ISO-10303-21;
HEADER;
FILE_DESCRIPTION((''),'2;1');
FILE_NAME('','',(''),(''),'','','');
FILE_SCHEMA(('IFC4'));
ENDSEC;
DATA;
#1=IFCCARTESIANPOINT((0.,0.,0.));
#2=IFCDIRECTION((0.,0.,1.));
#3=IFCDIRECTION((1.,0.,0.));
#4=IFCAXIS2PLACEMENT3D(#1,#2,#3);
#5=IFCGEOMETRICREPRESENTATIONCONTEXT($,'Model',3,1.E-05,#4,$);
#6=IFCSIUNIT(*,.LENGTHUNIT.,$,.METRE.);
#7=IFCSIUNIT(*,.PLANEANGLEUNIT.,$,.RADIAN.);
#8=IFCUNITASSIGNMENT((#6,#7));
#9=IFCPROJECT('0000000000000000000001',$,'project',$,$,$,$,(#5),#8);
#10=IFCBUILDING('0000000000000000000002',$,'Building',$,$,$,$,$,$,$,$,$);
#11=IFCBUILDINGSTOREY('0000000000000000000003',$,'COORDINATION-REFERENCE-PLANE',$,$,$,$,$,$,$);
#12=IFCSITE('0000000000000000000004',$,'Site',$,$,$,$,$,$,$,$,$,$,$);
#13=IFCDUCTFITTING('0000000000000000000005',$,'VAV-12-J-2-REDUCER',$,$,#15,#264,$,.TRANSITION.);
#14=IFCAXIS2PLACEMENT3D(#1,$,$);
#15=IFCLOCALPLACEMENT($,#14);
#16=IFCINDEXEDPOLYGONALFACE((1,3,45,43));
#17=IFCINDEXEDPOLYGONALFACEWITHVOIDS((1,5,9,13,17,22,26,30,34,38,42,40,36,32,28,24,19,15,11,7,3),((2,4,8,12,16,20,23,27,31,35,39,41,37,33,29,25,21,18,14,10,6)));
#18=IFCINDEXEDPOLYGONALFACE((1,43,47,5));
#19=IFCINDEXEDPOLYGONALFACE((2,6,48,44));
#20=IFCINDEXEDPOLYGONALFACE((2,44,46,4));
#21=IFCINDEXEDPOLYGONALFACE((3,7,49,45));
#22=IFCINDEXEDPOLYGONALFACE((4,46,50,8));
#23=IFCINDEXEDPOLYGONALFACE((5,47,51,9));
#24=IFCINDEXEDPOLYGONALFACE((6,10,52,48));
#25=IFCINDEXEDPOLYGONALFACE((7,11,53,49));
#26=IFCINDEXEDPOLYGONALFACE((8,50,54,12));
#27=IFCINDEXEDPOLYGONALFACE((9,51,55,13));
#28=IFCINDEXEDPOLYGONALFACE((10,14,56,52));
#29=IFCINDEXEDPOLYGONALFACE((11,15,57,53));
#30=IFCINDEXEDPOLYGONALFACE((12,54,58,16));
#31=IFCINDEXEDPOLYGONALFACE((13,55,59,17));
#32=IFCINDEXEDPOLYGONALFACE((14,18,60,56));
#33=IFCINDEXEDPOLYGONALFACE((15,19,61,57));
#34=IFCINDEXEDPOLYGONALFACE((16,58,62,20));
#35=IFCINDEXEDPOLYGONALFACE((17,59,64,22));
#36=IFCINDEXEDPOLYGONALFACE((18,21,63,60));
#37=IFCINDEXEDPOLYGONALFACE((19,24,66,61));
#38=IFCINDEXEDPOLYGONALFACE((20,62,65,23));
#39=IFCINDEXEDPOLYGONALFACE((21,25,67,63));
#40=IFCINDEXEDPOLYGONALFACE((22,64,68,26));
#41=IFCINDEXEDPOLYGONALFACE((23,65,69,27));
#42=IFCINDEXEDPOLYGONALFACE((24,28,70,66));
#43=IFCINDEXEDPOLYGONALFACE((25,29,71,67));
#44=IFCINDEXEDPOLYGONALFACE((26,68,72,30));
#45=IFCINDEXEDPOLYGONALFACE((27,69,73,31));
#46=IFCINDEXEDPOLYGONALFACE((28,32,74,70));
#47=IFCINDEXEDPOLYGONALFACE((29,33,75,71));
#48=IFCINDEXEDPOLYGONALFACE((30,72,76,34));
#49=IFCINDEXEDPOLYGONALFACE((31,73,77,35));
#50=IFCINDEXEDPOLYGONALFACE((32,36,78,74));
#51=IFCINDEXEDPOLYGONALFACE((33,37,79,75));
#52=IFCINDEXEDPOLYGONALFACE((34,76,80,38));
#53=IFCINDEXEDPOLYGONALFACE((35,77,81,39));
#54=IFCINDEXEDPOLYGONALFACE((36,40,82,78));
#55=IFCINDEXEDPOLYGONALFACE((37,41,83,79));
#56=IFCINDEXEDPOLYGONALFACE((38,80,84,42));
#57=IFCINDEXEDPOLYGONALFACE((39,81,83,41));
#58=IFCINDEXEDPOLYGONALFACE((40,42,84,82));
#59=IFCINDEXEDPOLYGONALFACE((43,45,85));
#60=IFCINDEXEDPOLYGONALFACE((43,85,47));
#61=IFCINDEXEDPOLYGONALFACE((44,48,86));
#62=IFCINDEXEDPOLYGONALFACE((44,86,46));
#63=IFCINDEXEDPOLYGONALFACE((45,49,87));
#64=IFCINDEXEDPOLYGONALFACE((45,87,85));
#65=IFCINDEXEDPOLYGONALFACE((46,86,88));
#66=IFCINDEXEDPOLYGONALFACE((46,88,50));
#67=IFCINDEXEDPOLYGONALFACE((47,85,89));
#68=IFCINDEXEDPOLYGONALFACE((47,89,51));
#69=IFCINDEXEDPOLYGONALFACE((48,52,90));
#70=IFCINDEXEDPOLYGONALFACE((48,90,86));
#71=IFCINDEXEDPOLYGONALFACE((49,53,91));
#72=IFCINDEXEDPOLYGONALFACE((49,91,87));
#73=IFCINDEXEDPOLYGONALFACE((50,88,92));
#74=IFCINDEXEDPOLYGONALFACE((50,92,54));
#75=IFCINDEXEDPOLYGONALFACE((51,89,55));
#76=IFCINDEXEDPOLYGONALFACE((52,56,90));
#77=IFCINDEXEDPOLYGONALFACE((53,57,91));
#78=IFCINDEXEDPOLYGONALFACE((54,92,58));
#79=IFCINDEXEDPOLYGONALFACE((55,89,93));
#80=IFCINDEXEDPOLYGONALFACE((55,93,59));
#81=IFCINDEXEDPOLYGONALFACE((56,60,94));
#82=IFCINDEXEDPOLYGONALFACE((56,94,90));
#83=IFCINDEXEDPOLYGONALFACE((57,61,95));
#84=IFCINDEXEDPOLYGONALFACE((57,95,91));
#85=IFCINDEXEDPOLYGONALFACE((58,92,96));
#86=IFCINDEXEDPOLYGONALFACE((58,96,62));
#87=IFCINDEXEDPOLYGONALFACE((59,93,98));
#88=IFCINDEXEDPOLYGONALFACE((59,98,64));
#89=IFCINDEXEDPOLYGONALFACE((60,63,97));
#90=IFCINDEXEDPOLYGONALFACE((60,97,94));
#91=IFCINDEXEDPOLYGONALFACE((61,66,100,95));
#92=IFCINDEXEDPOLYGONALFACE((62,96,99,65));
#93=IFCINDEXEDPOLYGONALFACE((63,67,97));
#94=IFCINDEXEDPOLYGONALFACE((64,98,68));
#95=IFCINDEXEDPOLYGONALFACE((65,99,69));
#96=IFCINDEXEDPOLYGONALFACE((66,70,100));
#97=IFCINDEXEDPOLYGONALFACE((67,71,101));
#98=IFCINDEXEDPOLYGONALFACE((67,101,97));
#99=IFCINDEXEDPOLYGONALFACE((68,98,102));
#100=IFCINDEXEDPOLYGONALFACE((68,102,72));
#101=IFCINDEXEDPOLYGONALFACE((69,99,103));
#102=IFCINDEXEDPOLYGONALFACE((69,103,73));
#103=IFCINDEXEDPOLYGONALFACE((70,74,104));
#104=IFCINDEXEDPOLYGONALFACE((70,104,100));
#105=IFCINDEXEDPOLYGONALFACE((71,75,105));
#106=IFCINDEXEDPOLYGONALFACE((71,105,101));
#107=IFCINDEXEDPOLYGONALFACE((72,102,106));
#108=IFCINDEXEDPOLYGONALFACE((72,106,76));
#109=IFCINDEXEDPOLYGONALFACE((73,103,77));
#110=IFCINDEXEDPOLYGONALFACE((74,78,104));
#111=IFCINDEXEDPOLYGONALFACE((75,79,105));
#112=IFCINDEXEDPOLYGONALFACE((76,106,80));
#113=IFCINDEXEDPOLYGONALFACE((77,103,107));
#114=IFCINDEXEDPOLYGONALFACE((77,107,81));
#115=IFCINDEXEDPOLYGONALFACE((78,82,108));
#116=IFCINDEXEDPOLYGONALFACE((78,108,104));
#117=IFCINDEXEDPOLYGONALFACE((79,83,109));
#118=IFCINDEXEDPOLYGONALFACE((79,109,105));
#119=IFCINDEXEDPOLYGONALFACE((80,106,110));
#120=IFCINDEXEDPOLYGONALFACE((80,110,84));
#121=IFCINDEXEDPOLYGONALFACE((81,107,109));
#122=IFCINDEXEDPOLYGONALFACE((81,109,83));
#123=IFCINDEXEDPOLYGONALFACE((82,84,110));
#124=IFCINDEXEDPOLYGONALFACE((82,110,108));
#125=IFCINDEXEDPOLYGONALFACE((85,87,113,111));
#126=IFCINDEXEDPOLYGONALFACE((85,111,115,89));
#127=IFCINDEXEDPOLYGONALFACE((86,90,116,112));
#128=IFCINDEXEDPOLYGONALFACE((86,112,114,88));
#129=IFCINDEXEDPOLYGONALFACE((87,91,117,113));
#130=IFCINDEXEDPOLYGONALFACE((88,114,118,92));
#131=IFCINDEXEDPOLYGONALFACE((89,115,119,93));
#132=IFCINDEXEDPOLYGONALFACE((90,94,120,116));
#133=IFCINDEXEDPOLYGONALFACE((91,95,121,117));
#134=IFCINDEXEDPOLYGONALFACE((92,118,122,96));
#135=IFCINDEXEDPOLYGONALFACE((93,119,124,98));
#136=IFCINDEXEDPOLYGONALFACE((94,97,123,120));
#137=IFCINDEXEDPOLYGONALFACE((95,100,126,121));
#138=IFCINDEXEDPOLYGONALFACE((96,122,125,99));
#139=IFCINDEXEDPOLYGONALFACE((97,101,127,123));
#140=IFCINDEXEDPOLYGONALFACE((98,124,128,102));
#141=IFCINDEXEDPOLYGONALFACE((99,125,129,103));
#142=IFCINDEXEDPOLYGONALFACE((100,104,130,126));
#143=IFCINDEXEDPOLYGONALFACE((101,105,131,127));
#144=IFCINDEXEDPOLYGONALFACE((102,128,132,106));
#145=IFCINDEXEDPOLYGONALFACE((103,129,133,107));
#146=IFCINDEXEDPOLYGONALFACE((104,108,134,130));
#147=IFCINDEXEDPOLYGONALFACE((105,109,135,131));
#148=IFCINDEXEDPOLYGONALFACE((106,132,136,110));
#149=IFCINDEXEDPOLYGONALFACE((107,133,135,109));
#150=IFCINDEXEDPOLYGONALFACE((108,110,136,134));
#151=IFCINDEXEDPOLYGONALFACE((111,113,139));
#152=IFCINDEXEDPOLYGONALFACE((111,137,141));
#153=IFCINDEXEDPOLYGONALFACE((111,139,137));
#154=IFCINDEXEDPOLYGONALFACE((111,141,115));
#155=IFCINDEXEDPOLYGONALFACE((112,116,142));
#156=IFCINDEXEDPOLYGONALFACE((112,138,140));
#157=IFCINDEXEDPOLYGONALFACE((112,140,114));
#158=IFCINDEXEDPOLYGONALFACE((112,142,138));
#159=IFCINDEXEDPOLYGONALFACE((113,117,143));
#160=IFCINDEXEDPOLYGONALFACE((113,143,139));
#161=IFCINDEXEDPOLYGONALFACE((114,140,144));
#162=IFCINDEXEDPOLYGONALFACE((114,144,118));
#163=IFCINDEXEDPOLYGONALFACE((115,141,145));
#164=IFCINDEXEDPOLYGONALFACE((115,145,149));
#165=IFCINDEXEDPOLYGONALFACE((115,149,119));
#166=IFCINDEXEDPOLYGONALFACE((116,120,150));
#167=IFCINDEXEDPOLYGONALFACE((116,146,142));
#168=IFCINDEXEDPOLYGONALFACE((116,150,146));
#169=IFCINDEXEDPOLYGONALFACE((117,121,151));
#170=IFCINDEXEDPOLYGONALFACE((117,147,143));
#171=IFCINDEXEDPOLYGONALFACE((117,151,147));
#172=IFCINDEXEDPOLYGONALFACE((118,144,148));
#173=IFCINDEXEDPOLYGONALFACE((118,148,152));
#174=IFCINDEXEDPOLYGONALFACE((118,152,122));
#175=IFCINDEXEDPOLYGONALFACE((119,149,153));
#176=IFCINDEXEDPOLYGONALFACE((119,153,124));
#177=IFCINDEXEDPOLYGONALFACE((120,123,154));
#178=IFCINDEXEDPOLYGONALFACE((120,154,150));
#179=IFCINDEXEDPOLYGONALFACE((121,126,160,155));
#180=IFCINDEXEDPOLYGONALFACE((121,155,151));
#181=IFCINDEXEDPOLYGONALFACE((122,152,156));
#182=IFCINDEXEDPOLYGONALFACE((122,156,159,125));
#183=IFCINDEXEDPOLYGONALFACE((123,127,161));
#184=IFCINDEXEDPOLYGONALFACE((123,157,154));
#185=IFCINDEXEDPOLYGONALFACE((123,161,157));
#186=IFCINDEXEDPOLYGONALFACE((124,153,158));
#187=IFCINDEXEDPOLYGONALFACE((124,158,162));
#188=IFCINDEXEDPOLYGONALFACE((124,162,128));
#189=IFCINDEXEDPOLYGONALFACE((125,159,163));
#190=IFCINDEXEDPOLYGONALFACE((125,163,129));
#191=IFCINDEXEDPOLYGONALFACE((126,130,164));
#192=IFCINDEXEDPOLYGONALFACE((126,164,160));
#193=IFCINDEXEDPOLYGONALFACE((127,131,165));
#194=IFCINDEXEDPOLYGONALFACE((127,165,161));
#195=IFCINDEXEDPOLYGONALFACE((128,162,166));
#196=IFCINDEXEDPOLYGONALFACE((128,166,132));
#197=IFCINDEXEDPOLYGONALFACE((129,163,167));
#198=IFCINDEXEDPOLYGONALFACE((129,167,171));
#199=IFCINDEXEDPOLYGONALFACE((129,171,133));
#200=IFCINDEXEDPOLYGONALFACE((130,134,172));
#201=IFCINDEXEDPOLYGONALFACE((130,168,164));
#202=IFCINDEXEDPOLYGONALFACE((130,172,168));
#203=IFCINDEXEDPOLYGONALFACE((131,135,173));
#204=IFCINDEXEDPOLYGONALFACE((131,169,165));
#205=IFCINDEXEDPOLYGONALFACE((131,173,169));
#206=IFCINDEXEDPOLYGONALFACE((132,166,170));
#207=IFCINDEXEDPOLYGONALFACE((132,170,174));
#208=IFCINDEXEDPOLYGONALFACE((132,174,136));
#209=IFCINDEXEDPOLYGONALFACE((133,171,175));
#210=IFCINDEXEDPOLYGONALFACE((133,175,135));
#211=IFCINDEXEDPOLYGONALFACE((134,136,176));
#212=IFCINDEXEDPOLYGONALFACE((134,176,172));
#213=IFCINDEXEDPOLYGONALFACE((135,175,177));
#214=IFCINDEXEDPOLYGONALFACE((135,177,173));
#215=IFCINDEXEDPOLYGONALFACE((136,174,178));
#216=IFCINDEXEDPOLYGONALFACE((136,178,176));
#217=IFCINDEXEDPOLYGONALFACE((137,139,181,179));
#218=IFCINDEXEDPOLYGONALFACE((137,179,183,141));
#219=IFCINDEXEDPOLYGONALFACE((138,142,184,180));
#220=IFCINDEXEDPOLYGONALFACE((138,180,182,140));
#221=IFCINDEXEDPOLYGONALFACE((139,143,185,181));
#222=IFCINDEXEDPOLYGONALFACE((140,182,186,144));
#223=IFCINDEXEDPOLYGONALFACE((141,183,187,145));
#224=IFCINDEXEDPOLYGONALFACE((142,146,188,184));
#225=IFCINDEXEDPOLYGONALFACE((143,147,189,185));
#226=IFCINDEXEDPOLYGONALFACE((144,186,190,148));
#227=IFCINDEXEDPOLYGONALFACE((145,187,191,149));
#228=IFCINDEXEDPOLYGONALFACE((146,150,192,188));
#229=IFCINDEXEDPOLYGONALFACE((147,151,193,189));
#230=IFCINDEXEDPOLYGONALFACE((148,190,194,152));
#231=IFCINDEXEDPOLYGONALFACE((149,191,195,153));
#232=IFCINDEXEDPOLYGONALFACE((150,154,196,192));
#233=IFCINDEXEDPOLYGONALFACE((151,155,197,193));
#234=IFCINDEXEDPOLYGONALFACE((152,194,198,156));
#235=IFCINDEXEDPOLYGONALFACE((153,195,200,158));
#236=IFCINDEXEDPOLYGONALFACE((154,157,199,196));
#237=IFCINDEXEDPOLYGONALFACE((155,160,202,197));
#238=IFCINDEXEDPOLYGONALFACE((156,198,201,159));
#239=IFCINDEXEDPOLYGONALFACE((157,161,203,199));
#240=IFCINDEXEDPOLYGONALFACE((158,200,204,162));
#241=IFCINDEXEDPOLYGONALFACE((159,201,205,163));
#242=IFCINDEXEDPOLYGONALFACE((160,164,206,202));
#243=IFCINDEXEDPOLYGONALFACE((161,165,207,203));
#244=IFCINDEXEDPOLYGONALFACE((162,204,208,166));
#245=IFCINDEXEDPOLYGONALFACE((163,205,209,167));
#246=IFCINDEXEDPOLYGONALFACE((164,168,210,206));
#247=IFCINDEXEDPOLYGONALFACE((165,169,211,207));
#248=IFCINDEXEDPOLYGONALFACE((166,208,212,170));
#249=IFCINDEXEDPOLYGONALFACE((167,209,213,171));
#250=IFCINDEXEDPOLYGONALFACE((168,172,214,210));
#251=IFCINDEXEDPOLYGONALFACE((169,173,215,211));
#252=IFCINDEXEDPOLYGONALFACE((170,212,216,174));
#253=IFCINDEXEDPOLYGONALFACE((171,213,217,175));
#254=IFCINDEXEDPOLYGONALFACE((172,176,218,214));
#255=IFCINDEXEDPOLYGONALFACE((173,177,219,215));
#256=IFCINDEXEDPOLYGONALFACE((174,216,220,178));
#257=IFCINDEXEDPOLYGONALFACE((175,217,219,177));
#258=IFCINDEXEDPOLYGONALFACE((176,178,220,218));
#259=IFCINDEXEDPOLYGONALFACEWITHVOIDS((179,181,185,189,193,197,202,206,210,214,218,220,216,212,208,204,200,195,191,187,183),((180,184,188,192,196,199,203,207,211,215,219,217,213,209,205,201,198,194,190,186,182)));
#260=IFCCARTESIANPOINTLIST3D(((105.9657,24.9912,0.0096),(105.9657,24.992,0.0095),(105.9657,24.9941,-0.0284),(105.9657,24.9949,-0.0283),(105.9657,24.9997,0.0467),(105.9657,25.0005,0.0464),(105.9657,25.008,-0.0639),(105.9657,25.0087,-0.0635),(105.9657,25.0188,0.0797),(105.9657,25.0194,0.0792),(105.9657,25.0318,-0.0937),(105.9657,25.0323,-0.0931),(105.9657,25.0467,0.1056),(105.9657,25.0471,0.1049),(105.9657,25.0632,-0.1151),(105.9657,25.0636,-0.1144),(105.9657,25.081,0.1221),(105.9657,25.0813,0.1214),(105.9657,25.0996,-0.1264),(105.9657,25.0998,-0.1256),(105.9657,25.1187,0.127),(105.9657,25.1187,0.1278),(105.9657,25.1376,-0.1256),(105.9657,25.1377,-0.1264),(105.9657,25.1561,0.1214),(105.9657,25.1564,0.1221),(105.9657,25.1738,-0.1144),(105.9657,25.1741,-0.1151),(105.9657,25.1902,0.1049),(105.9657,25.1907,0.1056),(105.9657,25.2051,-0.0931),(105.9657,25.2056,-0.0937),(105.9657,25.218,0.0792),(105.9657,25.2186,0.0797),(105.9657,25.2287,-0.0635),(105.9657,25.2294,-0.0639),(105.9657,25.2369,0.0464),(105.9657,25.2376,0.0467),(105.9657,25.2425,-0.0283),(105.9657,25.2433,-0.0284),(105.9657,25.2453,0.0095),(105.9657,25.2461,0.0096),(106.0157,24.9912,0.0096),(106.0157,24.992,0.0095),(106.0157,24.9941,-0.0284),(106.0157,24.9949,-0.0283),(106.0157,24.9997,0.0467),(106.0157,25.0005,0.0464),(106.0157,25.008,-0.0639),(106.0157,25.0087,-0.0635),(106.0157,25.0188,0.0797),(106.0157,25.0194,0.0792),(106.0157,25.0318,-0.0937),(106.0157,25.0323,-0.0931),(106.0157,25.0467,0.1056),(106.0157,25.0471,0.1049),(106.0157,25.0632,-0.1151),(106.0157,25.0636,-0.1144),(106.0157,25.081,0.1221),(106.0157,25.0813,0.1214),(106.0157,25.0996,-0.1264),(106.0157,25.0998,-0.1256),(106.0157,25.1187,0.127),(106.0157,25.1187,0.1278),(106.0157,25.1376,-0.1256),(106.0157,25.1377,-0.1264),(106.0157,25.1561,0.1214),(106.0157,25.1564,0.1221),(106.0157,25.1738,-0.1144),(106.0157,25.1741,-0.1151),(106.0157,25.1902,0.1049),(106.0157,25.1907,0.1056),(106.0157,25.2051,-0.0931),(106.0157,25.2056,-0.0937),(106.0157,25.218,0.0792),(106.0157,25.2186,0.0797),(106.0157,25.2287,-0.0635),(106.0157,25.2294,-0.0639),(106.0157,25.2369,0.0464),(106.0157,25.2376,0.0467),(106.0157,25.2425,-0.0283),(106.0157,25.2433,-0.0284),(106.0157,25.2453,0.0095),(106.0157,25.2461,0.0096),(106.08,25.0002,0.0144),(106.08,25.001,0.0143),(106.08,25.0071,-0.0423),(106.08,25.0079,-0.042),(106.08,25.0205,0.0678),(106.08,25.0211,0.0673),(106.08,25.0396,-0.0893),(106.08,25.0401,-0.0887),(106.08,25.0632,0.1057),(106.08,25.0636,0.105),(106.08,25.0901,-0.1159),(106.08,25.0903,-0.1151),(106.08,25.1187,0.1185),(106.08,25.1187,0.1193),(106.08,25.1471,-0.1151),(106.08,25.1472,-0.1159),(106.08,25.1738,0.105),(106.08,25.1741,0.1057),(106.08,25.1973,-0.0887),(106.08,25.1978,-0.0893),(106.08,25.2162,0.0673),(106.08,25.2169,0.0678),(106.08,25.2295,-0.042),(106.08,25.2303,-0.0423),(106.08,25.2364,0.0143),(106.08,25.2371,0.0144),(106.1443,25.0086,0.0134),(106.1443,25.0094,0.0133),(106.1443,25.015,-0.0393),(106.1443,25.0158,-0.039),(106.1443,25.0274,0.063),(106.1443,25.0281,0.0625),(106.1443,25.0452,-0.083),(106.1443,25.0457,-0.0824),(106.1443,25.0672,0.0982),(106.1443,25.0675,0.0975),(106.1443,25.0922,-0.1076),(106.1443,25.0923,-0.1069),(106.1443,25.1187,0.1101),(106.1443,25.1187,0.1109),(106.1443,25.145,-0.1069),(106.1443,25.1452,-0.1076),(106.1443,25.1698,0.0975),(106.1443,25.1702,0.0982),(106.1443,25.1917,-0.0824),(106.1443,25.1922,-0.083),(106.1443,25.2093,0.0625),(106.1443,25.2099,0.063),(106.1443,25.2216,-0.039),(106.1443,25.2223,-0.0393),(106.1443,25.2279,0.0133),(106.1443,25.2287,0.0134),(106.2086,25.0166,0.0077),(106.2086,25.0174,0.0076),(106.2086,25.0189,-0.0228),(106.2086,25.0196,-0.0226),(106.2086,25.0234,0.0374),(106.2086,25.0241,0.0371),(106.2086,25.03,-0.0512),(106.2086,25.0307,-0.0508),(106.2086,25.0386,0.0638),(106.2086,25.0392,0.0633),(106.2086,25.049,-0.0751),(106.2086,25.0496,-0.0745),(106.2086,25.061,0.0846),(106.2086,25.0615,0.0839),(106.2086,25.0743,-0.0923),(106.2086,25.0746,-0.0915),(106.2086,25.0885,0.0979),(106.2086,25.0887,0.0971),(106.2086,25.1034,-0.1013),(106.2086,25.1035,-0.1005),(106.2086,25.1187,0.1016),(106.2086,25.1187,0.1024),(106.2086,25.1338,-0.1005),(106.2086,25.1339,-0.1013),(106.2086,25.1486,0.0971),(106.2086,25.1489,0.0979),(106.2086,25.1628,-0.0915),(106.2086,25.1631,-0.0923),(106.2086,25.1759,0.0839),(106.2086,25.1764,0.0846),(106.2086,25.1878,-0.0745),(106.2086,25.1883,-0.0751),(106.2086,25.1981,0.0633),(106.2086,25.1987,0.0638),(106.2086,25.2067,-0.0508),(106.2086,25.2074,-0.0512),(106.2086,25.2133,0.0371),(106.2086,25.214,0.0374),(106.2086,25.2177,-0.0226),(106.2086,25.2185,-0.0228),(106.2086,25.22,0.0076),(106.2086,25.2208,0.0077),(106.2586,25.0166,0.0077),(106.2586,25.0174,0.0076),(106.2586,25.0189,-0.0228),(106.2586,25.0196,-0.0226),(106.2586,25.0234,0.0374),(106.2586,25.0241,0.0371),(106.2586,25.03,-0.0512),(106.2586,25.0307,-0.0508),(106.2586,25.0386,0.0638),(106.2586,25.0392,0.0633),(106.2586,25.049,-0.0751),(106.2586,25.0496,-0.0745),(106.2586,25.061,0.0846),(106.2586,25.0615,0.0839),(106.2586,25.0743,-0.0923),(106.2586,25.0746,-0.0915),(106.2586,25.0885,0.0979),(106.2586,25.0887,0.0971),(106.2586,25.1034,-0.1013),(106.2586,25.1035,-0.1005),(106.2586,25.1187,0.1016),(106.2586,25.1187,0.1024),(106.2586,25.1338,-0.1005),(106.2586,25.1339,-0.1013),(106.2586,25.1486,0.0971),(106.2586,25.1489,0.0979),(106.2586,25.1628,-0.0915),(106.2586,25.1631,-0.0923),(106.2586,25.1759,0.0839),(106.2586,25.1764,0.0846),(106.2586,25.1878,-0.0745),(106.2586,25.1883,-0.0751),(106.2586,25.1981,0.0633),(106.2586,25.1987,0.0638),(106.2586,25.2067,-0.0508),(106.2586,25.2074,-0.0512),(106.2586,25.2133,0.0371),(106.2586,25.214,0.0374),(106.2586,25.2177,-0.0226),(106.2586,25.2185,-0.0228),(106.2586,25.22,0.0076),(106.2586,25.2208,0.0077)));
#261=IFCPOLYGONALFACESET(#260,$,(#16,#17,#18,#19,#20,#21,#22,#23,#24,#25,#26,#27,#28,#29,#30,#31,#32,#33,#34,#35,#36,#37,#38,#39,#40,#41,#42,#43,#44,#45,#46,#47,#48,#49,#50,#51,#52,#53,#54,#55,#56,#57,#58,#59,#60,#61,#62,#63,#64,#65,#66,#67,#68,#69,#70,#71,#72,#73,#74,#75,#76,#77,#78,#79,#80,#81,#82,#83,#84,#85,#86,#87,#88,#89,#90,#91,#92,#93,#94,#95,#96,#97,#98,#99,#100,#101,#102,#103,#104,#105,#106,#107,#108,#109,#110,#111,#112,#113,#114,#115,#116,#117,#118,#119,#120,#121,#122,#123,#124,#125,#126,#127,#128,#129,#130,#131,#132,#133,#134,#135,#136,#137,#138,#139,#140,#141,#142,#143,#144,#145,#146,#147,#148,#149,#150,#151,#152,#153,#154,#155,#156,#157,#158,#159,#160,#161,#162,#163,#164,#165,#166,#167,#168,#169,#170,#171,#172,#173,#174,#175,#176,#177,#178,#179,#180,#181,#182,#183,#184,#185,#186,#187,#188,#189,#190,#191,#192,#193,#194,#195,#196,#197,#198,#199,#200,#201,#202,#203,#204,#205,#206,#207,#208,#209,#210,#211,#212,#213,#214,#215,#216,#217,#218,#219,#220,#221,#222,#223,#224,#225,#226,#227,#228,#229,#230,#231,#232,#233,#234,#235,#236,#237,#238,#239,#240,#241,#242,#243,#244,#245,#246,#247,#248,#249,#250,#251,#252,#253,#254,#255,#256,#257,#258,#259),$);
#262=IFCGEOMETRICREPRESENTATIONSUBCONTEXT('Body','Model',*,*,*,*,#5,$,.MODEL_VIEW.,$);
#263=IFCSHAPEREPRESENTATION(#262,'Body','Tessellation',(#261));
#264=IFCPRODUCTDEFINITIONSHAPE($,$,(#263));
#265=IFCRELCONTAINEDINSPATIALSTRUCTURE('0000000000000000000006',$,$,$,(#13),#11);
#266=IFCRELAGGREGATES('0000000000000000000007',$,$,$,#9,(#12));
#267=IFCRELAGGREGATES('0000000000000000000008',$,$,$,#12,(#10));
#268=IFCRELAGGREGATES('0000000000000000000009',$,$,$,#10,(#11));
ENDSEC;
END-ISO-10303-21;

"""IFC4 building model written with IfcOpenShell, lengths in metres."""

from ifc_helpers import new_model, entity, si_unit, frame, origin_with_axes, place, context, subcontext, project, spatial, element, save


model = new_model("IFC4")

# Units and contexts
model_context = context("Model", 3, precision=1e-05, world=origin_with_axes())
body_context_1 = subcontext(model_context, "Body", "Model", "MODEL_VIEW")
ifc_project = project(units=[si_unit("LENGTHUNIT", "METRE"), si_unit("PLANEANGLEUNIT", "RADIAN")], contexts=[model_context])

# Site, building, storey
site = spatial("IfcSite", under=ifc_project, Name="Site")
building = spatial("IfcBuilding", under=site, Name="Building")
storey = spatial("IfcBuildingStorey", under=building, Name="COORDINATION-REFERENCE-PLANE")

# Duct fitting
for number, where, z_axis, x_axis, name in (
    (1, (105.9657, 25.1187, 0.0), (0.0, 1.0, 0.0), (0.0, 0.0, 1.0), "VAV-12-J-2-REDUCER"),
):
    element("IfcDuctFitting", number, at=place(None, frame(where, z_axis=z_axis, x_axis=x_axis)), inside=storey, Name=name, PredefinedType="TRANSITION", context=body_context_1, shape_type="SweptSolid", body=[
        entity("IfcRevolvedAreaSolid", entity("IfcArbitraryClosedProfileDef", "AREA", None, entity("IfcPolyline", [entity("IfcCartesianPoint", [0.1278, 0.0]), entity("IfcCartesianPoint", [0.1278, 0.05]), entity("IfcCartesianPoint", [0.1024, 0.2429]), entity("IfcCartesianPoint", [0.1024, 0.2929]), entity("IfcCartesianPoint", [0.1016, 0.2929]), entity("IfcCartesianPoint", [0.1016, 0.2429]), entity("IfcCartesianPoint", [0.127, 0.05]), entity("IfcCartesianPoint", [0.127, 0.0]), entity("IfcCartesianPoint", [0.1278, 0.0])])), entity("IfcAxis2Placement3D", entity("IfcCartesianPoint", [0.0, 0.0, 0.0])), entity("IfcAxis1Placement", entity("IfcCartesianPoint", [0.0, 0.0, 0.0]), entity("IfcDirection", [0.0, 1.0, 0.0])), 6.283185),
    ])

save(model, "model.ifc")
